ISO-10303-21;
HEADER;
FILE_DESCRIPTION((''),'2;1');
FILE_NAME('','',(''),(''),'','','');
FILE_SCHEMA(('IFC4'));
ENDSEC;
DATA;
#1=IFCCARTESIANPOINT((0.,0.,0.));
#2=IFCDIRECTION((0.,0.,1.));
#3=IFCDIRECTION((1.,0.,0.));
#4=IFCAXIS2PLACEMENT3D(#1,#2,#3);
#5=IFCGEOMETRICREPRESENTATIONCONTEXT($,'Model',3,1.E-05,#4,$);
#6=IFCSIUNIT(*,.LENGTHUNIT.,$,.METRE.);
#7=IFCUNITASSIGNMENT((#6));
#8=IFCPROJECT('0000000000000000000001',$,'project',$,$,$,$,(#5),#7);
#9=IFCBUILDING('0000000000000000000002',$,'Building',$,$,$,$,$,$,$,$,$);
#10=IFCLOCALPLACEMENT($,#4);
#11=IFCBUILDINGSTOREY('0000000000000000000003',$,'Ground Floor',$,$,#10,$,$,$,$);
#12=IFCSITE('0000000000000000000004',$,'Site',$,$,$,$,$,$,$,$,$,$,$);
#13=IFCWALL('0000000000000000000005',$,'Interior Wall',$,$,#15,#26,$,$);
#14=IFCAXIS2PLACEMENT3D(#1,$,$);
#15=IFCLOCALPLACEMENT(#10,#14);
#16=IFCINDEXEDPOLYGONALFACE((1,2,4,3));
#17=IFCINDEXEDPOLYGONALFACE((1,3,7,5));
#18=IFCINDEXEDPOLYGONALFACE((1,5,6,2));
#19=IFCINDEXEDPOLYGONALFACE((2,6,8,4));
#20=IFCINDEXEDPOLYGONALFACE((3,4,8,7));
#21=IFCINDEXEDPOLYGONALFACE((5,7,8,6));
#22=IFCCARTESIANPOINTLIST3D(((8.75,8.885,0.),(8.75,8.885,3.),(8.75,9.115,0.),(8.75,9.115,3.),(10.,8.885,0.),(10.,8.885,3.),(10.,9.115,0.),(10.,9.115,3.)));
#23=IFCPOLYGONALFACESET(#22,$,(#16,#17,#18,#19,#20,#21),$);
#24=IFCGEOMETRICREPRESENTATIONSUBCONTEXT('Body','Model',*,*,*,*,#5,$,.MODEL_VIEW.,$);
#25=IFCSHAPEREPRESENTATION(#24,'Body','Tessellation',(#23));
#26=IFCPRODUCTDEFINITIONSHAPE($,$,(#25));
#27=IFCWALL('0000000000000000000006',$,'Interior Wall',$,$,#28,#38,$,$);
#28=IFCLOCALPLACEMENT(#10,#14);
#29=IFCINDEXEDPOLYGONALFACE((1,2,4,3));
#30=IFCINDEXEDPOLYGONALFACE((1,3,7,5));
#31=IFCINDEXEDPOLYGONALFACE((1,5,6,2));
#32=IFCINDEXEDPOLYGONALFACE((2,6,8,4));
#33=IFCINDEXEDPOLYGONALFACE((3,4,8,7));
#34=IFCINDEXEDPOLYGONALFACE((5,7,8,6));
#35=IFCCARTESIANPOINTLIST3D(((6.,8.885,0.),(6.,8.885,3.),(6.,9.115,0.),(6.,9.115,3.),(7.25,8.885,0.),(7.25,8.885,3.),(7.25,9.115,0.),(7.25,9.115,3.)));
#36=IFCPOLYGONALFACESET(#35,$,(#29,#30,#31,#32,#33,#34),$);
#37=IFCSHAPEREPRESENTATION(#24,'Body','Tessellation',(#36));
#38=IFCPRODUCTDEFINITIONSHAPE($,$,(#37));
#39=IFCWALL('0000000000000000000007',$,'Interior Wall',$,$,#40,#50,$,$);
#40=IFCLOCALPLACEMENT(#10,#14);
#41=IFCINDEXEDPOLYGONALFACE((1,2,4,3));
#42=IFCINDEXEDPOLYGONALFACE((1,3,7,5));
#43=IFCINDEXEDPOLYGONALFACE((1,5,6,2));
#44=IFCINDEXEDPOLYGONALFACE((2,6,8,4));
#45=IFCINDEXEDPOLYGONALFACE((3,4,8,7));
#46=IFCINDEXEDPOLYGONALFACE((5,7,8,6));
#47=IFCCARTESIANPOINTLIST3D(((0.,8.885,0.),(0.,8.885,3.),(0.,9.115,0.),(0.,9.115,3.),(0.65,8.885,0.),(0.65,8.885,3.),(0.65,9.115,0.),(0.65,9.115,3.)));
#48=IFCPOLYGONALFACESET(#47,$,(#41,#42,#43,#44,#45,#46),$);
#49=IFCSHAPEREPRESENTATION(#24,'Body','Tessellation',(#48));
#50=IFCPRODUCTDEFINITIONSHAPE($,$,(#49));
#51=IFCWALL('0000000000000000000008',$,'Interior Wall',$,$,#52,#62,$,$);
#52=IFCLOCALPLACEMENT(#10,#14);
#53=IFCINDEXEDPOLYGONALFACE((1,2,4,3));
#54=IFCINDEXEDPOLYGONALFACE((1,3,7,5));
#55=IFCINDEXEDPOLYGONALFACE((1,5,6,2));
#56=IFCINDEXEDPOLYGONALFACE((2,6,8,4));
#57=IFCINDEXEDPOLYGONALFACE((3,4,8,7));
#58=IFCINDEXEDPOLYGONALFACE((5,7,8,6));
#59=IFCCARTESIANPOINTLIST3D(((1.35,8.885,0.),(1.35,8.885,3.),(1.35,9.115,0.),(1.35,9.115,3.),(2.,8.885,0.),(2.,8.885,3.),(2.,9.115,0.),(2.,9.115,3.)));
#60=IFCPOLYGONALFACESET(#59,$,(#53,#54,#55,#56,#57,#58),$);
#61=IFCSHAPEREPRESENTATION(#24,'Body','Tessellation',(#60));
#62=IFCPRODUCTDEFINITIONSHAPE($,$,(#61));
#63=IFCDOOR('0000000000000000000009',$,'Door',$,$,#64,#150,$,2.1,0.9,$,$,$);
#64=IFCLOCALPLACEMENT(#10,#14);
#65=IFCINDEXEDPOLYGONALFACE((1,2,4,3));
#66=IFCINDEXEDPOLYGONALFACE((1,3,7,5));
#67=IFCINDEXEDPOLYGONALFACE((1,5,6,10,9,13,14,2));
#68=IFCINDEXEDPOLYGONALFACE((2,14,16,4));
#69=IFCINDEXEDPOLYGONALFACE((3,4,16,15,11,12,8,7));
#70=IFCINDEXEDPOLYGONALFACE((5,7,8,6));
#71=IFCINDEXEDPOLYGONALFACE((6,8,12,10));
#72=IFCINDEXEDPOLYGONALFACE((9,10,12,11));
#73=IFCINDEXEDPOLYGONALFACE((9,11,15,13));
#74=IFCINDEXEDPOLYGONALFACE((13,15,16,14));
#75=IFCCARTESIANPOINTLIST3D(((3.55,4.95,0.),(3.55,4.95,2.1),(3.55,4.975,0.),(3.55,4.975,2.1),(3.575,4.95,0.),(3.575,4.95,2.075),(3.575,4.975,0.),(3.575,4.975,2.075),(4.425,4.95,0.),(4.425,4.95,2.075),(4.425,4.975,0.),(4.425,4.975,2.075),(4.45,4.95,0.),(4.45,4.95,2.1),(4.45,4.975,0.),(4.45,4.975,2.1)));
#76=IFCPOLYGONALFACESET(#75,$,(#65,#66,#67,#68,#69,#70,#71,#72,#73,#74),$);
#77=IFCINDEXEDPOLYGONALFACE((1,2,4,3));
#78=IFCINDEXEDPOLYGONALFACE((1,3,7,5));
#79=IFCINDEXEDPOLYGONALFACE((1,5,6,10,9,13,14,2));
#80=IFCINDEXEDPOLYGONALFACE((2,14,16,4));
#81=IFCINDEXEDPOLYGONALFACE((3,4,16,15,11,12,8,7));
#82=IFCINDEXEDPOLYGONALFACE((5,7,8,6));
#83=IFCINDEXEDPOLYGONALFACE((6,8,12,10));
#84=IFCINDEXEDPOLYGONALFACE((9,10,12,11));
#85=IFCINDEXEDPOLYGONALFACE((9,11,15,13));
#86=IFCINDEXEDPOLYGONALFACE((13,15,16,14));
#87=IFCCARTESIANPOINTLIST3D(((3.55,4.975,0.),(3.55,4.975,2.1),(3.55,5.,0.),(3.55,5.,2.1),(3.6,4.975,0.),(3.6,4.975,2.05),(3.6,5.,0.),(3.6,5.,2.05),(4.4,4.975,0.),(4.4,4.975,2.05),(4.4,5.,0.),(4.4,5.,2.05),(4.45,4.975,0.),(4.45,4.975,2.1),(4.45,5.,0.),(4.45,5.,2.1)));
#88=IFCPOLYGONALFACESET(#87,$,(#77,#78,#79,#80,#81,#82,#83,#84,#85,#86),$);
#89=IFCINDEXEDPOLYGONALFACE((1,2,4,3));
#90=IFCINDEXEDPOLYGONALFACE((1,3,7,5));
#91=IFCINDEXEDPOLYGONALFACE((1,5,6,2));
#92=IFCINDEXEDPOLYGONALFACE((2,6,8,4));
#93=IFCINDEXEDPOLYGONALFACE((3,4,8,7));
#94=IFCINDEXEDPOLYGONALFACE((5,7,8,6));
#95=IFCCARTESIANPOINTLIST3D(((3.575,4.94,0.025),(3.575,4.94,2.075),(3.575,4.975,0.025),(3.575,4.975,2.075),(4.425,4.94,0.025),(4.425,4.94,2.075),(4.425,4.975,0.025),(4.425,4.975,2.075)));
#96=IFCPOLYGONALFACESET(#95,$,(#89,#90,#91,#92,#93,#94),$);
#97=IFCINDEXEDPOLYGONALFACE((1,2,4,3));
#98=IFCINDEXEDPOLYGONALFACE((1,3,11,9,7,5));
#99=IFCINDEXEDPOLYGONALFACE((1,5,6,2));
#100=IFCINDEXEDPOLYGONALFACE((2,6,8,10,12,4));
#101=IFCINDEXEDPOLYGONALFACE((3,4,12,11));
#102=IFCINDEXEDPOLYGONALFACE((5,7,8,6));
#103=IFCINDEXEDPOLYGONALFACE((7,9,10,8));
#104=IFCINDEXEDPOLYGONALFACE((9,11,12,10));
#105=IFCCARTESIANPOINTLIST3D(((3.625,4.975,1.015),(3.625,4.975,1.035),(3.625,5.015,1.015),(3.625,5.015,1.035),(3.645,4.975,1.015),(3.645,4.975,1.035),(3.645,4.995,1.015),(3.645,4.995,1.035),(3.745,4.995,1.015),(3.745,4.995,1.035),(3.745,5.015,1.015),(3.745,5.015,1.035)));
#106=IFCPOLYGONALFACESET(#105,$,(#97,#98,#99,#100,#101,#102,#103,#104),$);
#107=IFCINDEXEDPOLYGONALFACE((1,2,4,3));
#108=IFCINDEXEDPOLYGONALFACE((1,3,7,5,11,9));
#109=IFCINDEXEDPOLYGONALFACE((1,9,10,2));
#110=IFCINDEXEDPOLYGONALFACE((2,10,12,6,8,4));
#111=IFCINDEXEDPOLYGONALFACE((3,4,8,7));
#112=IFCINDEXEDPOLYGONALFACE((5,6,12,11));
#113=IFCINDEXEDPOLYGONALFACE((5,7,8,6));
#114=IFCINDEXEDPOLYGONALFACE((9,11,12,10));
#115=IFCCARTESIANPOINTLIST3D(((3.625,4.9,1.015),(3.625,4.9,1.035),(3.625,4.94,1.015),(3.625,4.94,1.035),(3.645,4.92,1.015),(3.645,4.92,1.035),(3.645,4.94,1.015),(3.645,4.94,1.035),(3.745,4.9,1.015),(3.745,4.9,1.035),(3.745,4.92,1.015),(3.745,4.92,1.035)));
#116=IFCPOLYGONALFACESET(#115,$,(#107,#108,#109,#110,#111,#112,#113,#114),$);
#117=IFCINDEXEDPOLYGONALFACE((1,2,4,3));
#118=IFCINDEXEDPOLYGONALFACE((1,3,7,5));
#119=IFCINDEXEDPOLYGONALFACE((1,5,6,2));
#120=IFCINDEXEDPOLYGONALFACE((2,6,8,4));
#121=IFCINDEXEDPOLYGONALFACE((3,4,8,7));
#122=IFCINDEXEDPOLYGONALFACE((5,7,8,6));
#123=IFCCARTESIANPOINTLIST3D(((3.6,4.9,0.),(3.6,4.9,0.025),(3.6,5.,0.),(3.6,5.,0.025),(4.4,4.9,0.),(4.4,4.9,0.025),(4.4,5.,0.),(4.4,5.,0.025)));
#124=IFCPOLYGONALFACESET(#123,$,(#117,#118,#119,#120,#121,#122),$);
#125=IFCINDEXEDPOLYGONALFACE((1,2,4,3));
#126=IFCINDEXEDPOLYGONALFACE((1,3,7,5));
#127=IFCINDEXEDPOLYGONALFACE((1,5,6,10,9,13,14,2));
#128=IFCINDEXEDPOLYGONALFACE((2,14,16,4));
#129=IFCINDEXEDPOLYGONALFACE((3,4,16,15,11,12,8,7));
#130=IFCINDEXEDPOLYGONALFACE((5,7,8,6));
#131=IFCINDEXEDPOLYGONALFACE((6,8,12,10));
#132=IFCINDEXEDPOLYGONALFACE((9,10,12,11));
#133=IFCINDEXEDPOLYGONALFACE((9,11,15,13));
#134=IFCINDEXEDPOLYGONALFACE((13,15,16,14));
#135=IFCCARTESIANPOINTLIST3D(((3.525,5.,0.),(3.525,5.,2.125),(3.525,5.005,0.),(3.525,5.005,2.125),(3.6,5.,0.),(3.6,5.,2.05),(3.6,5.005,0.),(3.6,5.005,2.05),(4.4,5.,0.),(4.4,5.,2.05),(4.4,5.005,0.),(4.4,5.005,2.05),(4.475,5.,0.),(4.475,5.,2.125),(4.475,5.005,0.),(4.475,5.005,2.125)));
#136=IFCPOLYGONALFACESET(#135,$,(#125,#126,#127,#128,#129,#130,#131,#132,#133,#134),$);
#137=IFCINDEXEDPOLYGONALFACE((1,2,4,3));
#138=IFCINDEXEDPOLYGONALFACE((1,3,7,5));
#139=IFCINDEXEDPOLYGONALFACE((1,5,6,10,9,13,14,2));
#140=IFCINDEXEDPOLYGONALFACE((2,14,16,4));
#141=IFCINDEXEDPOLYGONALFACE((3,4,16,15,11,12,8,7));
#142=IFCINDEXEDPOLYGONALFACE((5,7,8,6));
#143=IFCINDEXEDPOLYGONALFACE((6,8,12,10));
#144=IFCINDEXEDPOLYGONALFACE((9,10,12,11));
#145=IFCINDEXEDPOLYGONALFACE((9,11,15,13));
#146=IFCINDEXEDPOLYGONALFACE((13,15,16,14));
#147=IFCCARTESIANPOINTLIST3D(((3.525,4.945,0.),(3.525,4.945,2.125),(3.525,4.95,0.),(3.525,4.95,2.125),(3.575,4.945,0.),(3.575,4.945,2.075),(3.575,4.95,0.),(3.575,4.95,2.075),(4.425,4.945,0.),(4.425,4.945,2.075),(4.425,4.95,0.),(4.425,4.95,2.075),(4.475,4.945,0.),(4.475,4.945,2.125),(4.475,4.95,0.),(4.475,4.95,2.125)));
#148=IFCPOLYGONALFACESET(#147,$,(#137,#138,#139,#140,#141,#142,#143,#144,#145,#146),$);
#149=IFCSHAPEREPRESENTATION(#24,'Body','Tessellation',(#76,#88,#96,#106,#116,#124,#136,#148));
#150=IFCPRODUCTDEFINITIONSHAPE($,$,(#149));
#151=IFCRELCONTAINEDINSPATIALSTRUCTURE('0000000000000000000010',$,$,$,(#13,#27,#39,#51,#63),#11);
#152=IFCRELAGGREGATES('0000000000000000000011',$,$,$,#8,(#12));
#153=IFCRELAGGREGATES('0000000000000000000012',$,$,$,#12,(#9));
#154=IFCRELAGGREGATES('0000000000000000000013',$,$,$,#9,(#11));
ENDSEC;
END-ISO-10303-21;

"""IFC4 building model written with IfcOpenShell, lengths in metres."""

from ifc_helpers import new_model, si_unit, frame, origin_with_axes, place, context, subcontext, project, spatial, line, indexed_curve, outline, extrude, element, save


model = new_model("IFC4")

# Units and contexts
model_context = context("Model", 3, precision=1e-05, world=origin_with_axes())
body_context = subcontext(model_context, "Body", "Model", "MODEL_VIEW")
ifc_project = project(units=[si_unit("LENGTHUNIT", "METRE")], contexts=[model_context])

# Site, building, storey
site = spatial("IfcSite", under=ifc_project, Name="Site")
building = spatial("IfcBuilding", under=site, Name="Building")
storey_placement = place(None, origin_with_axes())
storey = spatial("IfcBuildingStorey", under=building, at=storey_placement, Name="Ground Floor")

# Walls
for number, where, z_axis, x_axis, name in (
    (1, (10.0, 9.0, 0.0), (0.0, 0.0, 1.0), (-1.0, 0.0, 0.0), "Interior Wall"),
    (2, (7.25, 9.0, 0.0), (0.0, 0.0, 1.0), (-1.0, 0.0, 0.0), "Interior Wall"),
):
    element("IfcWall", number, at=place(storey_placement, frame(where, z_axis=z_axis, x_axis=x_axis)), inside=storey, Name=name, context=body_context, shape_type="SweptSolid", body=[
        extrude(outline(indexed_curve([(0.0, 0.0), (0.0, 0.23), (1.25, 0.23), (1.25, 0.0), (0.0, 0.0)], self_intersect=False)), frame((0.0, -0.115, 0.0), z_axis=(0.0, 0.0, 1.0), x_axis=(1.0, 0.0, 0.0)), (0.0, 0.0, 1.0), 3.0),
    ])
wall_1_placement = place(storey_placement, frame((0.0, 9.0, 0.0), z_axis=(0.0, 0.0, 1.0), x_axis=(1.0, 0.0, 0.0)))
element("IfcWall", 3, at=wall_1_placement, inside=storey, Name="Interior Wall", context=body_context, shape_type="SweptSolid", body=[
    extrude(outline(indexed_curve([(0.0, 0.0), (0.0, 0.23), (0.65, 0.23), (0.65, 0.0), (0.0, 0.0)], self_intersect=False)), frame((0.0, -0.115, 0.0), z_axis=(0.0, 0.0, 1.0), x_axis=(1.0, 0.0, 0.0)), (0.0, 0.0, 1.0), 3.0),
])
wall_2_placement = place(storey_placement, frame((1.35, 9.0, 0.0), z_axis=(0.0, 0.0, 1.0), x_axis=(1.0, 0.0, 0.0)))
element("IfcWall", 4, at=wall_2_placement, inside=storey, Name="Interior Wall", context=body_context, shape_type="SweptSolid", body=[
    extrude(outline(indexed_curve([(0.0, 0.0), (0.0, 0.23), (0.65, 0.23), (0.65, 0.0), (0.0, 0.0)], self_intersect=False)), frame((0.0, -0.115, 0.0), z_axis=(0.0, 0.0, 1.0), x_axis=(1.0, 0.0, 0.0)), (0.0, 0.0, 1.0), 3.0),
])

# Door
door_1_placement = place(storey_placement, frame((4.45, 5.0, 0.0), z_axis=(0.0, 0.0, 1.0), x_axis=(-1.0, 0.0, 0.0)))
element("IfcDoor", 5, at=door_1_placement, inside=storey, Name="Door", OverallHeight=2.1, OverallWidth=0.9, context=body_context, shape_type="SweptSolid", body=[
    extrude(outline(indexed_curve([(0.0, 0.0), (0.0, 2.1), (0.9, 2.1), (0.9, 0.0), (0.875, 0.0), (0.875, 2.075), (0.025, 2.075), (0.025, 0.0)], segments=[line(1, 2, 3, 4, 5, 6, 7, 8, 1)])), frame((0.0, 0.025, 0.0), z_axis=(0.0, -1.0, 0.0), x_axis=(1.0, 0.0, 0.0)), (0.0, 0.0, -1.0), 0.025),
    extrude(outline(indexed_curve([(0.0, 0.0), (0.0, 2.1), (0.9, 2.1), (0.9, 0.0), (0.85, 0.0), (0.85, 2.05), (0.05, 2.05), (0.05, 0.0)], segments=[line(1, 2, 3, 4, 5, 6, 7, 8, 1)])), frame((0.0, 0.0, 0.0), z_axis=(0.0, -1.0, 0.0), x_axis=(1.0, 0.0, 0.0)), (0.0, 0.0, -1.0), 0.025),
    extrude(outline(indexed_curve([(0.0, 0.0), (0.85, 0.0), (0.85, 0.035), (0.0, 0.035)], segments=[line(1, 2, 3, 4, 1)])), frame((0.025, 0.025, 0.025), z_axis=(0.0, 0.0, 1.0), x_axis=(1.0, 0.0, 0.0)), (0.0, 0.0, 1.0), 2.05),
    extrude(outline(indexed_curve([(0.0, 0.0), (0.0, -0.04), (-0.12, -0.04), (-0.12, -0.02), (-0.02, -0.02), (-0.02, 0.0)], segments=[line(1, 2, 3, 4, 5, 6, 1)])), frame((0.825, 0.025, 1.015), z_axis=(0.0, 0.0, 1.0), x_axis=(1.0, 0.0, 0.0)), (0.0, 0.0, 1.0), 0.02),
    extrude(outline(indexed_curve([(0.0, 0.0), (0.0, 0.04), (-0.12, 0.04), (-0.12, 0.02), (-0.02, 0.02), (-0.02, 0.0)], segments=[line(1, 2, 3, 4, 5, 6, 1)])), frame((0.825, 0.06, 1.015), z_axis=(0.0, 0.0, 1.0), x_axis=(1.0, 0.0, 0.0)), (0.0, 0.0, 1.0), 0.02),
    extrude(outline(indexed_curve([(0.0, 0.0), (0.8, 0.0), (0.8, 0.1), (0.0, 0.1)], segments=[line(1, 2, 3, 4, 1)])), frame((0.05, 0.0, 0.0), z_axis=(0.0, 0.0, 1.0), x_axis=(1.0, 0.0, 0.0)), (0.0, 0.0, 1.0), 0.025),
    extrude(outline(indexed_curve([(0.0, 0.0), (0.0, 2.125), (0.95, 2.125), (0.95, 0.0), (0.875, 0.0), (0.875, 2.05), (0.075, 2.05), (0.075, 0.0)], segments=[line(1, 2, 3, 4, 5, 6, 7, 8, 1)])), frame((-0.025, -0.005, 0.0), z_axis=(0.0, -1.0, 0.0), x_axis=(1.0, 0.0, 0.0)), (0.0, 0.0, -1.0), 0.005),
    extrude(outline(indexed_curve([(0.0, 0.0), (0.0, 2.125), (0.95, 2.125), (0.95, 0.0), (0.9, 0.0), (0.9, 2.075), (0.05, 2.075), (0.05, 0.0)], segments=[line(1, 2, 3, 4, 5, 6, 7, 8, 1)])), frame((-0.025, 0.05, 0.0), z_axis=(0.0, -1.0, 0.0), x_axis=(1.0, 0.0, 0.0)), (0.0, 0.0, -1.0), 0.005),
])

save(model, "model.ifc")
